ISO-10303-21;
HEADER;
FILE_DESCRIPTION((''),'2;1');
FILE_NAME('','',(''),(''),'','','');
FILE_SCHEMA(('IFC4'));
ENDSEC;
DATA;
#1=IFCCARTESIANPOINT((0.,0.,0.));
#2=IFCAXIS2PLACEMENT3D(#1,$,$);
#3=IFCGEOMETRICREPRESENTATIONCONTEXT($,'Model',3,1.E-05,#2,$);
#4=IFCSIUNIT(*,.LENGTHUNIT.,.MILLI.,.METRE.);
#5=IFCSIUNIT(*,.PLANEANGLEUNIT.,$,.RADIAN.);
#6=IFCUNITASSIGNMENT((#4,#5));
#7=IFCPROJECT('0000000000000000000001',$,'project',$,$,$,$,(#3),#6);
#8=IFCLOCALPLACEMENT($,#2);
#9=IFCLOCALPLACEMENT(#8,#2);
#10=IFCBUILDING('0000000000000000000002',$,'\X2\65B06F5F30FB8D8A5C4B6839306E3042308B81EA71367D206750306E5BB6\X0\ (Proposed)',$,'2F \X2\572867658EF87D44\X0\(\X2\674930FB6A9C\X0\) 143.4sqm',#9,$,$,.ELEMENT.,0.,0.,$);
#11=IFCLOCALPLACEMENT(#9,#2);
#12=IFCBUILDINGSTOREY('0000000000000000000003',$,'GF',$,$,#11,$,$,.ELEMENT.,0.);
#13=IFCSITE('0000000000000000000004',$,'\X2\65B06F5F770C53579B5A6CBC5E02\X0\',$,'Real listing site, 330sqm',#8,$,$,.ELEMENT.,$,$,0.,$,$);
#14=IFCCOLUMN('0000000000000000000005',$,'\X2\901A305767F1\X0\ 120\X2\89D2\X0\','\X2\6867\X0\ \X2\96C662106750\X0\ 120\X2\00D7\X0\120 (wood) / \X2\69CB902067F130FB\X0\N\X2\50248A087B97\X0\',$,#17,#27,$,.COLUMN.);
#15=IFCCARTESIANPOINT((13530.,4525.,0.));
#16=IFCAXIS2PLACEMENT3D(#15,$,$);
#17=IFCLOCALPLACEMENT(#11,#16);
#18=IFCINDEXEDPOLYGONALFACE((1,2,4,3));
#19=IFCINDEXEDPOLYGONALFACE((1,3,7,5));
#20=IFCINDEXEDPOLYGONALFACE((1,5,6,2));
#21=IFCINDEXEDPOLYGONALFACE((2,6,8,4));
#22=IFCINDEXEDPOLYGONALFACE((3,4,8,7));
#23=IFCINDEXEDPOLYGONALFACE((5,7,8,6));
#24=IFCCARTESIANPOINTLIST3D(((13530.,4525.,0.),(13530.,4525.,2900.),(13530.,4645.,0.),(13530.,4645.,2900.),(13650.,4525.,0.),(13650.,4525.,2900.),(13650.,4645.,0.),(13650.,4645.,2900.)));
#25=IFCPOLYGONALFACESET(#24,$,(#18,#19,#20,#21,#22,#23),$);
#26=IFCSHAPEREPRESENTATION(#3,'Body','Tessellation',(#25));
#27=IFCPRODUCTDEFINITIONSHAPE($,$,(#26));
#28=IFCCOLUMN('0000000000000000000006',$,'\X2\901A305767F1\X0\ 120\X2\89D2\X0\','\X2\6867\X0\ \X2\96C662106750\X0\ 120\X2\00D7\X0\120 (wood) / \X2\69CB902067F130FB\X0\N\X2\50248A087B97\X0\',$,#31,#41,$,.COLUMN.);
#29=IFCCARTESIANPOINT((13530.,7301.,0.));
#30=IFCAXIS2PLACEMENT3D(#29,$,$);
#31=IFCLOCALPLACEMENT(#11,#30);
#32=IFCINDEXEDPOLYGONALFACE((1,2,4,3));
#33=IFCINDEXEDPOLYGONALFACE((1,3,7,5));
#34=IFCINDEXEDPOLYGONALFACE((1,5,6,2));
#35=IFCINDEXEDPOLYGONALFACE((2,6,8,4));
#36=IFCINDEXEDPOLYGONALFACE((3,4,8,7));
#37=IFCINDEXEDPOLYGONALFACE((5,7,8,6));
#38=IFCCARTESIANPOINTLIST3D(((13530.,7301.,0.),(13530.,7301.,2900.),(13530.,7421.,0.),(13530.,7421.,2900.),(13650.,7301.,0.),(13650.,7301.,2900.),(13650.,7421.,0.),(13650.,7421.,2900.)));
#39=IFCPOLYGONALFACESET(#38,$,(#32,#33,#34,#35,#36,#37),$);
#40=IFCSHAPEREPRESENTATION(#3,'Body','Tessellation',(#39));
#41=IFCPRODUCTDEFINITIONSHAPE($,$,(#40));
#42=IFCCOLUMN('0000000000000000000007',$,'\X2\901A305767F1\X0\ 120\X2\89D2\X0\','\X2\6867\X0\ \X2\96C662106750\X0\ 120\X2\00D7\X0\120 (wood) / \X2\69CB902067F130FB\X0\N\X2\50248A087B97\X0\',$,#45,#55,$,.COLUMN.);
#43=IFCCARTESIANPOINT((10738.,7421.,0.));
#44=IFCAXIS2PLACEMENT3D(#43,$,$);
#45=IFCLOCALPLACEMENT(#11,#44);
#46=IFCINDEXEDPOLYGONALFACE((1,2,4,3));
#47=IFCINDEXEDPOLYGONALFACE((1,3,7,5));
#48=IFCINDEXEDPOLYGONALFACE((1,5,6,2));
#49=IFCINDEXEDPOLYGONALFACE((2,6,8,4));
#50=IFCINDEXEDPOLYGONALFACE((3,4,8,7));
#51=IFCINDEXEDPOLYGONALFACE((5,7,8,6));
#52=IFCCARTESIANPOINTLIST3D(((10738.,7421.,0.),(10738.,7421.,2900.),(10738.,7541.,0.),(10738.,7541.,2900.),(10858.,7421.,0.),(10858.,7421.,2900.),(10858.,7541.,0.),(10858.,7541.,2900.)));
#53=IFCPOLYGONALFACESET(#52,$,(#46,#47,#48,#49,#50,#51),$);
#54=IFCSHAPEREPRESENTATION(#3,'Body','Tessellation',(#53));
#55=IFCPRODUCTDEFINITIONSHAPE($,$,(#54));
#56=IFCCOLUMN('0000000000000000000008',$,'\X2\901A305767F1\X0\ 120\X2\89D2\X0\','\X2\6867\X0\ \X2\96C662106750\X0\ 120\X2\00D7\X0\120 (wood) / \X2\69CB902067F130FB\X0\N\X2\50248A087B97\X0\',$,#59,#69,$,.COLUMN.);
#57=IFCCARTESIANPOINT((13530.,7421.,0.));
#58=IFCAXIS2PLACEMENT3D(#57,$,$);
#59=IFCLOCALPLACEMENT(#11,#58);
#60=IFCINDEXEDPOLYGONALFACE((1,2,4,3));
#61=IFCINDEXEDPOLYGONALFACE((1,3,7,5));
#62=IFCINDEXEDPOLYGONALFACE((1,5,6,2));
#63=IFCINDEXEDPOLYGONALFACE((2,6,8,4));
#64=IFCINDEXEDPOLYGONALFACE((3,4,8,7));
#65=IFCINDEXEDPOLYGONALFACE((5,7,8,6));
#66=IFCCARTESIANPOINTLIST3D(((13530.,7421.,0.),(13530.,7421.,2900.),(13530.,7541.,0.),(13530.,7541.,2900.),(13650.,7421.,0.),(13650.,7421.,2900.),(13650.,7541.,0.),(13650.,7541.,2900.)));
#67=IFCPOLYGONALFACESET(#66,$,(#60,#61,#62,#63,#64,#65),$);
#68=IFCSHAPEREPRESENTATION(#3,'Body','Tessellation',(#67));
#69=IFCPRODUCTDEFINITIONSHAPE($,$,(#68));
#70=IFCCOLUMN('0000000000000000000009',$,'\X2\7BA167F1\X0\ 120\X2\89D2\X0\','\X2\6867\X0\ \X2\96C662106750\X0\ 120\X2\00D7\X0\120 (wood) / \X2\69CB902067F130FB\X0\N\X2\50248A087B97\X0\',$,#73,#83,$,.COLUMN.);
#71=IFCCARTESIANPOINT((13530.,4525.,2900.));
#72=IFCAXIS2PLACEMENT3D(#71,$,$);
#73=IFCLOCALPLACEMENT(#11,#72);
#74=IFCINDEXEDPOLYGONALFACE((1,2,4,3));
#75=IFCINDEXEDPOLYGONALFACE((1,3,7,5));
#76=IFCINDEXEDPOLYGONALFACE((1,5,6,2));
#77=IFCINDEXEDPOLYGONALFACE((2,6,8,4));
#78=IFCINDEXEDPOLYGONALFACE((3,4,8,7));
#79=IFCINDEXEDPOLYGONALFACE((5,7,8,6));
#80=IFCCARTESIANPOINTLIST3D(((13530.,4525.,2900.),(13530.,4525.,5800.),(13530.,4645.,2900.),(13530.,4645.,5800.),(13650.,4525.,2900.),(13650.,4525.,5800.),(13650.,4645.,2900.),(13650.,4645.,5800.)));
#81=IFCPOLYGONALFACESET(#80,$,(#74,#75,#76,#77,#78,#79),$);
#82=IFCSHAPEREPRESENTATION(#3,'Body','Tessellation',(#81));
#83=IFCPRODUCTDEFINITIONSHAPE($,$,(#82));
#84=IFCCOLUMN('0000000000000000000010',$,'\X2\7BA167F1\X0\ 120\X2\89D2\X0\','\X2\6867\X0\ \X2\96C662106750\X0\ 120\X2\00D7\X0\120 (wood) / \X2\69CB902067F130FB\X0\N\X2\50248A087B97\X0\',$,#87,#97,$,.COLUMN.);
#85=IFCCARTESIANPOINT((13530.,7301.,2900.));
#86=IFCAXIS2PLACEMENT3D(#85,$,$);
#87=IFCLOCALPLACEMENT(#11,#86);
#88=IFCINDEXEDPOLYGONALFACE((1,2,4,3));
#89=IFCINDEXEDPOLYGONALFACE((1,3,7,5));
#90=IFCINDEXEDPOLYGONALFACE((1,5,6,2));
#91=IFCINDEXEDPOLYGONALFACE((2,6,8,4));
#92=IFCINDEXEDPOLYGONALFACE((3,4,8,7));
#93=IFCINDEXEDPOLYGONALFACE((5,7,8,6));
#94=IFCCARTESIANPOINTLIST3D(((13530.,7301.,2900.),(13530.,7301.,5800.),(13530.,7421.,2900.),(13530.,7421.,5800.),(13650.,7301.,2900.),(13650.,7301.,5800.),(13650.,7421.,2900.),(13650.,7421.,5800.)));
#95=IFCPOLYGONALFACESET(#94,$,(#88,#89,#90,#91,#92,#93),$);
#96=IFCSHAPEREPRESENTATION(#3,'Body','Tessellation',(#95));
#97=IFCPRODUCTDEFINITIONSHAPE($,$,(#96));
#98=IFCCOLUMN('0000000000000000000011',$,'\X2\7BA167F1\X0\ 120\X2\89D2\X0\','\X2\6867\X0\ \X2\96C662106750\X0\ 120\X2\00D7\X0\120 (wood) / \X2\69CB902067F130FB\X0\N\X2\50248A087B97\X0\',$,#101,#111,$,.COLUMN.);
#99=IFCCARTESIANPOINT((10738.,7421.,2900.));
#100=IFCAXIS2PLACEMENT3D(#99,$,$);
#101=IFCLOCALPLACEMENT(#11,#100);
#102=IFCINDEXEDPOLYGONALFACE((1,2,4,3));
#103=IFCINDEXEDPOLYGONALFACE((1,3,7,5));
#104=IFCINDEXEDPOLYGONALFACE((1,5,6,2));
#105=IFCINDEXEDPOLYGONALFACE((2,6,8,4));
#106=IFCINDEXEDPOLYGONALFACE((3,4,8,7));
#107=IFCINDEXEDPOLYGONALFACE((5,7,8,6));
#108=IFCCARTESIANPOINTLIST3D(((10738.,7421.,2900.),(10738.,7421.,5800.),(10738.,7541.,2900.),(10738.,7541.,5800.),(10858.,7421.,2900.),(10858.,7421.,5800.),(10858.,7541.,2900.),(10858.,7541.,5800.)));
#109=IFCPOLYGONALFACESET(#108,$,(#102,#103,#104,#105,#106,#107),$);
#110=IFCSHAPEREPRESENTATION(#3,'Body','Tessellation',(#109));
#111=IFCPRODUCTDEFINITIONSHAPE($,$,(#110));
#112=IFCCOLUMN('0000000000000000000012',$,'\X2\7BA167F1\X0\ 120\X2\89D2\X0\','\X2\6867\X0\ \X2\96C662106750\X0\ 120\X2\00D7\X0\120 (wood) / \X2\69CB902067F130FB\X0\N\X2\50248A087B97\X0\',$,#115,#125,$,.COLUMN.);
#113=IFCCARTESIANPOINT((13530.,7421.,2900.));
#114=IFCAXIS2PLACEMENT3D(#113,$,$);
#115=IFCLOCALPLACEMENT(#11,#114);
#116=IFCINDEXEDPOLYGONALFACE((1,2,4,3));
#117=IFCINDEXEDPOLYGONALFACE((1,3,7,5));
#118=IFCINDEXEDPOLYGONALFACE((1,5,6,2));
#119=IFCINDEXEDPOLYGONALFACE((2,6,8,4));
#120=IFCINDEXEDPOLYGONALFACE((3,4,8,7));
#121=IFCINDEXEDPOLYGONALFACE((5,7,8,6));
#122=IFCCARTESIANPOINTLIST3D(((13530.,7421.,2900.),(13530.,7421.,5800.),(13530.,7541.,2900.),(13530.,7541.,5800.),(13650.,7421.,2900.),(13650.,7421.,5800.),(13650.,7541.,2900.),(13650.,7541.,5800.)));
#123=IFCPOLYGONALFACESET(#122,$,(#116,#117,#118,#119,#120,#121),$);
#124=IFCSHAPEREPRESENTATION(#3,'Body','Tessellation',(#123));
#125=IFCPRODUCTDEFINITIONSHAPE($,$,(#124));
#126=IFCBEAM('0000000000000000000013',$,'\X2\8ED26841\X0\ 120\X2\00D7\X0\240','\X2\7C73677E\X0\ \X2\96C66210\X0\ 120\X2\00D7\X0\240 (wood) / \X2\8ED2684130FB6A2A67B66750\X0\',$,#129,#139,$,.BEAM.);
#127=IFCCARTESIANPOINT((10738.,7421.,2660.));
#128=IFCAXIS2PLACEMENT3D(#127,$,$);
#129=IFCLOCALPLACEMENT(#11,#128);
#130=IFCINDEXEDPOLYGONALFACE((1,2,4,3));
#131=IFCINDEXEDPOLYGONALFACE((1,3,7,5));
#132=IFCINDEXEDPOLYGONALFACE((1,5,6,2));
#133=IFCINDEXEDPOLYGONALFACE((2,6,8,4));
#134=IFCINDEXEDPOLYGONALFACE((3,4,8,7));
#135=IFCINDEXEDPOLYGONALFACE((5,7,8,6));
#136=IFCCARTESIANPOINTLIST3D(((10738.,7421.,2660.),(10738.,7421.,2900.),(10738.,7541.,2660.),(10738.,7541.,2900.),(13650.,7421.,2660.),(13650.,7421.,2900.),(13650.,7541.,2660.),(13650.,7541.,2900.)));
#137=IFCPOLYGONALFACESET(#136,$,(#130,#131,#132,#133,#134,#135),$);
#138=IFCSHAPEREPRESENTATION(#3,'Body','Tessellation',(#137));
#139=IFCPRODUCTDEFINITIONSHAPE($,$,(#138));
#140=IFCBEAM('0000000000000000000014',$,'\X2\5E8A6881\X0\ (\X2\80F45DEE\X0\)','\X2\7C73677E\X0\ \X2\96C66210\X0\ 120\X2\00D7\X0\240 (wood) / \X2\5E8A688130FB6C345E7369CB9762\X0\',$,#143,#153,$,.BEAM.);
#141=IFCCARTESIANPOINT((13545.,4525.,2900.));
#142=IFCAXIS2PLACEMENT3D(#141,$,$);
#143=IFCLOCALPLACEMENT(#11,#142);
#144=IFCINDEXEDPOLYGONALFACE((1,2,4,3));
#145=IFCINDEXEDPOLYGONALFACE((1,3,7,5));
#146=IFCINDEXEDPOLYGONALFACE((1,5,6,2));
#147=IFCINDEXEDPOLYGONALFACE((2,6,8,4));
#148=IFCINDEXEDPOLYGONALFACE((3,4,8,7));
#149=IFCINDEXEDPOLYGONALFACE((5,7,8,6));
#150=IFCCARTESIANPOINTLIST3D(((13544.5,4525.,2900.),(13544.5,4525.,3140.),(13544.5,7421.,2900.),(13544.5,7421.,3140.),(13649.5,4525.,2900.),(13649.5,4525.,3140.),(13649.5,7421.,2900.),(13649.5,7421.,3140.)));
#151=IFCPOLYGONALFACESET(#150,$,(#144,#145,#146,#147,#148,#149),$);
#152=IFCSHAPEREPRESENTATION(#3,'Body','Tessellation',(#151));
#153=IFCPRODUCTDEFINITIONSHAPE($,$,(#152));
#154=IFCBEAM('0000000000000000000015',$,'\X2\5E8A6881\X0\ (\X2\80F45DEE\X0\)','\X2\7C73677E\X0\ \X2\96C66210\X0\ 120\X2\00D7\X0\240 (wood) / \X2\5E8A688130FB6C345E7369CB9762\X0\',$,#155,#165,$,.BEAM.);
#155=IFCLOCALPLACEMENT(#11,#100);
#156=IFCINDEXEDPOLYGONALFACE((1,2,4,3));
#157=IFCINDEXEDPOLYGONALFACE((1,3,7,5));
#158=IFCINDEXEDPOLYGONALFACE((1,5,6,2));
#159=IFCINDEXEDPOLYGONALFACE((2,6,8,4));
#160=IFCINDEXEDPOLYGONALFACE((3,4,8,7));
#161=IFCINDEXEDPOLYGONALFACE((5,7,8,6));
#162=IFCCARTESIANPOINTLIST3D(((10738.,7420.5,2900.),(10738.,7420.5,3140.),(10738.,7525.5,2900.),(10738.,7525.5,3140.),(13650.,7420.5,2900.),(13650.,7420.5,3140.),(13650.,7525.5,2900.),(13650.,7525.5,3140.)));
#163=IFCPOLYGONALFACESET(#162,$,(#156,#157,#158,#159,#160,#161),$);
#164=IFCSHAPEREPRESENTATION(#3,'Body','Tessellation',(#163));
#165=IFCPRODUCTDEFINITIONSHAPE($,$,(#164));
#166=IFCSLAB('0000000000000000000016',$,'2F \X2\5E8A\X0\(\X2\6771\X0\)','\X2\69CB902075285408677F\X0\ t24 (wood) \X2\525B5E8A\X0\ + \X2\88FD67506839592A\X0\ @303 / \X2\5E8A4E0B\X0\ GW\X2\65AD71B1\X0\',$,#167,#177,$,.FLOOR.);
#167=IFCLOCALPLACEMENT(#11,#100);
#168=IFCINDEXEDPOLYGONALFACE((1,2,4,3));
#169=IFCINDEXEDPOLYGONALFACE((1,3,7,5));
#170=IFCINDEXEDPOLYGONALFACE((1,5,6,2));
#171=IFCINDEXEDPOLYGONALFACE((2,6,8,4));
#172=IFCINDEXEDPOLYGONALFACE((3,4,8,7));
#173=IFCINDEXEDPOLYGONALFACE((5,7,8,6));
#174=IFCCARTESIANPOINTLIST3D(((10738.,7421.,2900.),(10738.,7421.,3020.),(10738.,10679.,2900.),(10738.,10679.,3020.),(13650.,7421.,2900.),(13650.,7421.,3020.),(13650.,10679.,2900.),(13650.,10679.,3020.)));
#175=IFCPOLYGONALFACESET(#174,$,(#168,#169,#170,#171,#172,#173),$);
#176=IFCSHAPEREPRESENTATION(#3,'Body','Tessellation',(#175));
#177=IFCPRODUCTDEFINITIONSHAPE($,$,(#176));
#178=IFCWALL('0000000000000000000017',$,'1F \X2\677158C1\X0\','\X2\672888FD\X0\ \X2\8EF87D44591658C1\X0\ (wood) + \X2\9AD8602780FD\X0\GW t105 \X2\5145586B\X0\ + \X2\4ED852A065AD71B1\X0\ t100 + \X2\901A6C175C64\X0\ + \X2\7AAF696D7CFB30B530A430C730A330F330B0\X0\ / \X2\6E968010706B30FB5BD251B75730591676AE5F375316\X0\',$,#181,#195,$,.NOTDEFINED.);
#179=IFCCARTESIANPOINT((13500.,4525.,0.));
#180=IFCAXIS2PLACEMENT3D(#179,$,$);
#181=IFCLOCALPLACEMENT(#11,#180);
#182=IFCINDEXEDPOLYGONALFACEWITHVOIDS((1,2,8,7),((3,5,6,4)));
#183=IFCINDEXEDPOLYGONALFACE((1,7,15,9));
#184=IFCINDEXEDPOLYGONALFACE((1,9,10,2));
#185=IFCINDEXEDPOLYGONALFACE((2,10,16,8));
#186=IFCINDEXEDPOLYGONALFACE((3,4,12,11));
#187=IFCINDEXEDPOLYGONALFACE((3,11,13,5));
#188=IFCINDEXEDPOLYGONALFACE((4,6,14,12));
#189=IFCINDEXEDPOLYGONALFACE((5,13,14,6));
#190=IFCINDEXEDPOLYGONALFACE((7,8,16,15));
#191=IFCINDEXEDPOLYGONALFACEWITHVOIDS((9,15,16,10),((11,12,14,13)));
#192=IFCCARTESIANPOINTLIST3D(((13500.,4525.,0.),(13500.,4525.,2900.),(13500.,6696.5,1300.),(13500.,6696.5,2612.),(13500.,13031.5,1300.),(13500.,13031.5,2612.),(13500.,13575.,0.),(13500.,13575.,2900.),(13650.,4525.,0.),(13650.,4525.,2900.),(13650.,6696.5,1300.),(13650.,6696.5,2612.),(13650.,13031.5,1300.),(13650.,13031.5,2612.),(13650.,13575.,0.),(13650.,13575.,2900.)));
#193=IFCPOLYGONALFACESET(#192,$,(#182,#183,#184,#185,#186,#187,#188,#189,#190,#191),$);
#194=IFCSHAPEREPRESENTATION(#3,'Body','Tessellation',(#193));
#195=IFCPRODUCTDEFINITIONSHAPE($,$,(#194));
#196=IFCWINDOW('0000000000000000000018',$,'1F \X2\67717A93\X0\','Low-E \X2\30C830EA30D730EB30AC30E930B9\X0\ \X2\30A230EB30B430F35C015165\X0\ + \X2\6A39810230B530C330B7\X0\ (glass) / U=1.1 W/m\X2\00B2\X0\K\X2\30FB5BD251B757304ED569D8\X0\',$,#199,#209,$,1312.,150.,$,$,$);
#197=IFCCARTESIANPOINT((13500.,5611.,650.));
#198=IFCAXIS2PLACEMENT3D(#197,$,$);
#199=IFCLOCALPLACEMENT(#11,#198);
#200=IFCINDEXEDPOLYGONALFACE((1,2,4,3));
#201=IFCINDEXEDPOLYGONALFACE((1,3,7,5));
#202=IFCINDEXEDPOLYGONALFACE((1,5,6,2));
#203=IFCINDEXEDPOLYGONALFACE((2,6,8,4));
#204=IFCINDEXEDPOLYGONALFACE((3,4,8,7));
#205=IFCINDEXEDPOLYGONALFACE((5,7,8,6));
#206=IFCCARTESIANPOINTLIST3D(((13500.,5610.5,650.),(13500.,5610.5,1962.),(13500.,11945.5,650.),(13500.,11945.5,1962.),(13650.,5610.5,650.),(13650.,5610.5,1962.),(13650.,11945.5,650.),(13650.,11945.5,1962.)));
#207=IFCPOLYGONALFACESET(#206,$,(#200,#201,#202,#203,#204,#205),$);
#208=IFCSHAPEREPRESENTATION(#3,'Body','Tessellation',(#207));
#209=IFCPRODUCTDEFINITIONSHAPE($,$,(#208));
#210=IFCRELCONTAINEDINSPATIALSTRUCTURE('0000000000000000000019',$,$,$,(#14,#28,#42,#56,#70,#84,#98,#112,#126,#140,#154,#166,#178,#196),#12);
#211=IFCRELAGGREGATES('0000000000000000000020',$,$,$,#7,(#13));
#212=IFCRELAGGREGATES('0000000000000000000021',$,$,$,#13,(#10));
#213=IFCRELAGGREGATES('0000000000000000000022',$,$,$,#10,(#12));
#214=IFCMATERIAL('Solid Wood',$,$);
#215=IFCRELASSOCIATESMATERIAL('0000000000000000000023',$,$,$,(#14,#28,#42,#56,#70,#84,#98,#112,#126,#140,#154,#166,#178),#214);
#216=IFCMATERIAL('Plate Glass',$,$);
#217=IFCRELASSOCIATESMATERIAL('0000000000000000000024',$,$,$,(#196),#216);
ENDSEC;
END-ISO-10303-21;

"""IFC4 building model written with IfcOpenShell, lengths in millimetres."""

from ifc_helpers import new_model, si_unit, frame, frame_2d, origin, place, context, project, spatial, rectangle, extrude, material, element, fill, save


model = new_model("IFC4")

# Units and contexts
model_context = context("Model", 3, precision=1e-05, world=origin())
ifc_project = project(units=[si_unit("LENGTHUNIT", "METRE", prefix="MILLI"), si_unit("PLANEANGLEUNIT", "RADIAN")], contexts=[model_context])

# Site, building, storey
site_placement = place(None, origin())
site = spatial("IfcSite", under=ifc_project, at=site_placement, Name="新潟県南魚沼市", ObjectType="Real listing site, 330sqm", CompositionType="ELEMENT", RefElevation=0.0)
building_placement = place(site_placement, origin())
building = spatial("IfcBuilding", under=site, at=building_placement, Name="新潟・越屋根のある自然素材の家 (Proposed)", ObjectType="2F 在来軸組(杉・檜) 143.4sqm", CompositionType="ELEMENT", ElevationOfRefHeight=0.0, ElevationOfTerrain=0.0)
storey_placement = place(building_placement, origin())
storey = spatial("IfcBuildingStorey", under=building, at=storey_placement, Name="GF", CompositionType="ELEMENT", Elevation=0.0)

# Columns
ifc_material_1 = material(Name="Solid Wood")
column_1_placement = place(storey_placement, frame((13530.0, 4525.0, 0.0)))
element("IfcColumn", 1, at=column_1_placement, inside=storey, material=ifc_material_1, Name="通し柱 120角", Description="桧 集成材 120×120 (wood) / 構造柱・N値計算", PredefinedType="COLUMN", context=model_context, shape_type="SweptSolid", body=[
    extrude(rectangle(XDim=120.0, YDim=120.0, at=frame_2d((60.0, 60.0))), frame((13530.0, 4525.0, 0.0)), (0.0, 0.0, 1.0), 2900.0),
])
column_2_placement = place(storey_placement, frame((13530.0, 7301.0, 0.0)))
element("IfcColumn", 2, at=column_2_placement, inside=storey, material=ifc_material_1, Name="通し柱 120角", Description="桧 集成材 120×120 (wood) / 構造柱・N値計算", PredefinedType="COLUMN", context=model_context, shape_type="SweptSolid", body=[
    extrude(rectangle(XDim=120.0, YDim=120.0, at=frame_2d((60.0, 60.0))), frame((13530.0, 7301.0, 0.0)), (0.0, 0.0, 1.0), 2900.0),
])
column_3_placement = place(storey_placement, frame((10738.0, 7421.0, 0.0)))
element("IfcColumn", 3, at=column_3_placement, inside=storey, material=ifc_material_1, Name="通し柱 120角", Description="桧 集成材 120×120 (wood) / 構造柱・N値計算", PredefinedType="COLUMN", context=model_context, shape_type="SweptSolid", body=[
    extrude(rectangle(XDim=120.0, YDim=120.0, at=frame_2d((60.0, 60.0))), frame((10738.0, 7421.0, 0.0)), (0.0, 0.0, 1.0), 2900.0),
])
column_4_placement = place(storey_placement, frame((13530.0, 7421.0, 0.0)))
element("IfcColumn", 4, at=column_4_placement, inside=storey, material=ifc_material_1, Name="通し柱 120角", Description="桧 集成材 120×120 (wood) / 構造柱・N値計算", PredefinedType="COLUMN", context=model_context, shape_type="SweptSolid", body=[
    extrude(rectangle(XDim=120.0, YDim=120.0, at=frame_2d((60.0, 60.0))), frame((13530.0, 7421.0, 0.0)), (0.0, 0.0, 1.0), 2900.0),
])
column_5_placement = place(storey_placement, frame((13530.0, 4525.0, 2900.0)))
element("IfcColumn", 5, at=column_5_placement, inside=storey, material=ifc_material_1, Name="管柱 120角", Description="桧 集成材 120×120 (wood) / 構造柱・N値計算", PredefinedType="COLUMN", context=model_context, shape_type="SweptSolid", body=[
    extrude(rectangle(XDim=120.0, YDim=120.0, at=frame_2d((60.0, 60.0))), frame((13530.0, 4525.0, 2900.0)), (0.0, 0.0, 1.0), 2900.0),
])
column_6_placement = place(storey_placement, frame((13530.0, 7301.0, 2900.0)))
element("IfcColumn", 6, at=column_6_placement, inside=storey, material=ifc_material_1, Name="管柱 120角", Description="桧 集成材 120×120 (wood) / 構造柱・N値計算", PredefinedType="COLUMN", context=model_context, shape_type="SweptSolid", body=[
    extrude(rectangle(XDim=120.0, YDim=120.0, at=frame_2d((60.0, 60.0))), frame((13530.0, 7301.0, 2900.0)), (0.0, 0.0, 1.0), 2900.0),
])
column_7_placement = place(storey_placement, frame((10738.0, 7421.0, 2900.0)))
element("IfcColumn", 7, at=column_7_placement, inside=storey, material=ifc_material_1, Name="管柱 120角", Description="桧 集成材 120×120 (wood) / 構造柱・N値計算", PredefinedType="COLUMN", context=model_context, shape_type="SweptSolid", body=[
    extrude(rectangle(XDim=120.0, YDim=120.0, at=frame_2d((60.0, 60.0))), frame((10738.0, 7421.0, 2900.0)), (0.0, 0.0, 1.0), 2900.0),
])
column_8_placement = place(storey_placement, frame((13530.0, 7421.0, 2900.0)))
element("IfcColumn", 8, at=column_8_placement, inside=storey, material=ifc_material_1, Name="管柱 120角", Description="桧 集成材 120×120 (wood) / 構造柱・N値計算", PredefinedType="COLUMN", context=model_context, shape_type="SweptSolid", body=[
    extrude(rectangle(XDim=120.0, YDim=120.0, at=frame_2d((60.0, 60.0))), frame((13530.0, 7421.0, 2900.0)), (0.0, 0.0, 1.0), 2900.0),
])

# Beams
beam_1_placement = place(storey_placement, frame((10738.0, 7421.0, 2660.0)))
element("IfcBeam", 9, at=beam_1_placement, inside=storey, material=ifc_material_1, Name="軒桁 120×240", Description="米松 集成 120×240 (wood) / 軒桁・横架材", PredefinedType="BEAM", context=model_context, shape_type="SweptSolid", body=[
    extrude(rectangle(XDim=2912.0, YDim=120.0, at=frame_2d((1456.0, 60.0))), frame((10738.0, 7421.0, 2660.0)), (0.0, 0.0, 1.0), 240.0),
])
beam_2_placement = place(storey_placement, frame((13545.0, 4525.0, 2900.0)))
element("IfcBeam", 10, at=beam_2_placement, inside=storey, material=ifc_material_1, Name="床梁 (胴差)", Description="米松 集成 120×240 (wood) / 床梁・水平構面", PredefinedType="BEAM", context=model_context, shape_type="SweptSolid", body=[
    extrude(rectangle(XDim=105.0, YDim=2896.0, at=frame_2d((52.0, 1448.0))), frame((13545.0, 4525.0, 2900.0)), (0.0, 0.0, 1.0), 240.0),
])
beam_3_placement = place(storey_placement, frame((10738.0, 7421.0, 2900.0)))
element("IfcBeam", 11, at=beam_3_placement, inside=storey, material=ifc_material_1, Name="床梁 (胴差)", Description="米松 集成 120×240 (wood) / 床梁・水平構面", PredefinedType="BEAM", context=model_context, shape_type="SweptSolid", body=[
    extrude(rectangle(XDim=2912.0, YDim=105.0, at=frame_2d((1456.0, 52.0))), frame((10738.0, 7421.0, 2900.0)), (0.0, 0.0, 1.0), 240.0),
])

# Slab
slab_placement = place(storey_placement, frame((10738.0, 7421.0, 2900.0)))
element("IfcSlab", 12, at=slab_placement, inside=storey, material=ifc_material_1, Name="2F 床(東)", Description="構造用合板 t24 (wood) 剛床 + 製材根太 @303 / 床下 GW断熱", PredefinedType="FLOOR", context=model_context, shape_type="SweptSolid", body=[
    extrude(rectangle(XDim=2912.0, YDim=3258.0, at=frame_2d((1456.0, 1629.0))), frame((10738.0, 7421.0, 2900.0)), (0.0, 0.0, 1.0), 120.0),
])

# Wall, opening, window
wall_1_placement = place(storey_placement, frame((13500.0, 4525.0, 0.0)))
wall_1 = element("IfcWall", 13, at=wall_1_placement, inside=storey, material=ifc_material_1, Name="1F 東壁", Description="木製 軸組外壁 (wood) + 高性能GW t105 充填 + 付加断熱 t100 + 通気層 + 窯業系サイディング / 準耐火・寒冷地外皮強化", PredefinedType="NOTDEFINED", context=model_context, shape_type="SweptSolid", body=[
    extrude(rectangle(XDim=150.0, YDim=9050.0, at=frame_2d((75.0, 4525.0))), frame((13500.0, 4525.0, 0.0)), (0.0, 0.0, 1.0), 2900.0),
])
opening_1_placement = place(storey_placement, frame((13500.0, 5611.0, 650.0)))
opening_1 = element("IfcOpeningElement", 14, at=opening_1_placement, cuts=wall_1, PredefinedType="NOTDEFINED", context=model_context, shape_type="SweptSolid", body=[
    extrude(rectangle(XDim=150.0, YDim=6335.0, at=frame_2d((75.0, 3167.0))), frame((13500.0, 5611.0, 650.0)), (0.0, 0.0, 1.0), 1312.0),
])
ifc_material_2 = material(Name="Plate Glass")
window_1_placement = place(storey_placement, frame((13500.0, 5611.0, 650.0)))
window_1 = element("IfcWindow", 15, at=window_1_placement, inside=storey, material=ifc_material_2, Name="1F 東窓", Description="Low-E トリプルガラス アルゴン封入 + 樹脂サッシ (glass) / U=1.1 W/m²K・寒冷地仕様", OverallHeight=1312.0, OverallWidth=150.0, context=model_context, shape_type="SweptSolid", body=[
    extrude(rectangle(XDim=150.0, YDim=6335.0, at=frame_2d((75.0, 3167.0))), frame((13500.0, 5611.0, 650.0)), (0.0, 0.0, 1.0), 1312.0),
])
fill(opening_1, window_1)

save(model, "model.ifc")
